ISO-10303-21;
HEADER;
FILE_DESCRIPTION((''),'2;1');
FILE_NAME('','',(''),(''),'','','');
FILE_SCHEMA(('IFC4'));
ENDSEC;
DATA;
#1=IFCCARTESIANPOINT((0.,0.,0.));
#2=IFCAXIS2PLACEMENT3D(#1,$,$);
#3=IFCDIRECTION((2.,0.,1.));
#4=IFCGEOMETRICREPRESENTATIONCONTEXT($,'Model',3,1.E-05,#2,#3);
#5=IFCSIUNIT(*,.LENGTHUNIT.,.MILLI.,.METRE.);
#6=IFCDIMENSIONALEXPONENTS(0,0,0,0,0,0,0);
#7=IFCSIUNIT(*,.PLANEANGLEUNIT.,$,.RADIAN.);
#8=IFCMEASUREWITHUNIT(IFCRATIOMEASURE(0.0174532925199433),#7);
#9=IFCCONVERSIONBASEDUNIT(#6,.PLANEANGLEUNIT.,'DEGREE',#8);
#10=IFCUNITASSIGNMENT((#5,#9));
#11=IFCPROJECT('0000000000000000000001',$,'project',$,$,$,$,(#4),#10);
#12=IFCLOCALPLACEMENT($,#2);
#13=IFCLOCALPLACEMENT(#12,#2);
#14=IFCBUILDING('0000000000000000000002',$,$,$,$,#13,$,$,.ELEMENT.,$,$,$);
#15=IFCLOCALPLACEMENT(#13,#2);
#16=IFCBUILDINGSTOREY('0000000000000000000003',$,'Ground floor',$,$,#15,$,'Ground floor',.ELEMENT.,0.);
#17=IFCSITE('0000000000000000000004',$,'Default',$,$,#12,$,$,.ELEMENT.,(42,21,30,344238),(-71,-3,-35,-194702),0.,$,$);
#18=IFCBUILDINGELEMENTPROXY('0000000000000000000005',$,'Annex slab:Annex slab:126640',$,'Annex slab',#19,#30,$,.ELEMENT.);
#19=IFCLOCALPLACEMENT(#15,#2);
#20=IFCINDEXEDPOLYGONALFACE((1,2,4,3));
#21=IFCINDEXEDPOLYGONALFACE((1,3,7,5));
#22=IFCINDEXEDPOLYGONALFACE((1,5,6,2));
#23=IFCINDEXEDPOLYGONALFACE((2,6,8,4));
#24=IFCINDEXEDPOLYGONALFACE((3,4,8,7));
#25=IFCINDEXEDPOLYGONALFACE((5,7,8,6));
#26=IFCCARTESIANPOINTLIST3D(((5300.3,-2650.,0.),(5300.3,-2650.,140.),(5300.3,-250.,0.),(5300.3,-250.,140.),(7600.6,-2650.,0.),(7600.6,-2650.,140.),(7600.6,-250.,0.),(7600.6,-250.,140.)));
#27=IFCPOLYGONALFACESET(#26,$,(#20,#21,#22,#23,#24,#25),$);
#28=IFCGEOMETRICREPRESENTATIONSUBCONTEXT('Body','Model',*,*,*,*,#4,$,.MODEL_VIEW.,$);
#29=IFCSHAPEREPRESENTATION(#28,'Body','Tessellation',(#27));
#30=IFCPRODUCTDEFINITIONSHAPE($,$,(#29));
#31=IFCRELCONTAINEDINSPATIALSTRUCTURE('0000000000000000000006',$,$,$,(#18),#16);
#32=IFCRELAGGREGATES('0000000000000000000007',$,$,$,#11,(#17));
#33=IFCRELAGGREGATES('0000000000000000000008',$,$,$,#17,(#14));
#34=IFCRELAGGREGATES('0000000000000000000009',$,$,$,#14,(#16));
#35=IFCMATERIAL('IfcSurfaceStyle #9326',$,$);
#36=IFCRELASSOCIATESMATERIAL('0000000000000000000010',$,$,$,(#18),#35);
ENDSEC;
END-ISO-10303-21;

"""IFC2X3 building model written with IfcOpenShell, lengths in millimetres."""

from ifc_helpers import new_model, entity, si_unit, converted_unit, direction, frame, frame_2d, origin, place, context, subcontext, project, spatial, rectangle, extrude, source, transform, mapped, material, element, save


model = new_model("IFC2X3")

# Units and contexts
model_context = context("Model", 3, precision=1e-05, world=origin(), true_north=direction((2.0, 0.0, 1.0)))
body_context = subcontext(model_context, "Body", "Model", "MODEL_VIEW")
ifc_project = project(units=[si_unit("LENGTHUNIT", "METRE", prefix="MILLI"), converted_unit("PLANEANGLEUNIT", "DEGREE", entity("IfcRatioMeasure", 0.0174532925199433), si_unit("PLANEANGLEUNIT", "RADIAN"), dimensions=[0, 0, 0, 0, 0, 0, 0])], contexts=[model_context])

# Site, building, storey
site_placement = place(None, origin())
site = spatial("IfcSite", under=ifc_project, at=site_placement, Name="Default", CompositionType="ELEMENT", RefLatitude=(42, 21, 30, 344238), RefLongitude=(-71, -3, -35, -194702), RefElevation=0.0)
building_placement = place(site_placement, origin())
building = spatial("IfcBuilding", under=site, at=building_placement, CompositionType="ELEMENT")
storey_placement = place(building_placement, origin())
storey = spatial("IfcBuildingStorey", under=building, at=storey_placement, Name="Ground floor", LongName="Ground floor", CompositionType="ELEMENT", Elevation=0.0)

# Building element proxy
ifc_material_1 = material(Name="IfcSurfaceStyle #9326")
shared_shape_1 = source(origin(), body_context, "Body", "SweptSolid", [
    extrude(rectangle(XDim=2300.3, YDim=2400.0, at=frame_2d((0.0, 0.0), x_axis=(1.0, 0.0))), frame((1150.2, 1200.0, 0.0)), (0.0, 0.0, 1.0), 140.0),
])
proxy_1_placement = place(building_placement, frame((5300.3, -2650.0, 0.0)))
element("IfcBuildingElementProxy", 1, at=proxy_1_placement, inside=storey, material=ifc_material_1, Name="Annex slab:Annex slab:126640", ObjectType="Annex slab", CompositionType="ELEMENT", context=body_context, shape_type="MappedRepresentation", body=[
    mapped(shared_shape_1, transform((0.0, 0.0, 0.0), scale=1.0)),
])

save(model, "model.ifc")
